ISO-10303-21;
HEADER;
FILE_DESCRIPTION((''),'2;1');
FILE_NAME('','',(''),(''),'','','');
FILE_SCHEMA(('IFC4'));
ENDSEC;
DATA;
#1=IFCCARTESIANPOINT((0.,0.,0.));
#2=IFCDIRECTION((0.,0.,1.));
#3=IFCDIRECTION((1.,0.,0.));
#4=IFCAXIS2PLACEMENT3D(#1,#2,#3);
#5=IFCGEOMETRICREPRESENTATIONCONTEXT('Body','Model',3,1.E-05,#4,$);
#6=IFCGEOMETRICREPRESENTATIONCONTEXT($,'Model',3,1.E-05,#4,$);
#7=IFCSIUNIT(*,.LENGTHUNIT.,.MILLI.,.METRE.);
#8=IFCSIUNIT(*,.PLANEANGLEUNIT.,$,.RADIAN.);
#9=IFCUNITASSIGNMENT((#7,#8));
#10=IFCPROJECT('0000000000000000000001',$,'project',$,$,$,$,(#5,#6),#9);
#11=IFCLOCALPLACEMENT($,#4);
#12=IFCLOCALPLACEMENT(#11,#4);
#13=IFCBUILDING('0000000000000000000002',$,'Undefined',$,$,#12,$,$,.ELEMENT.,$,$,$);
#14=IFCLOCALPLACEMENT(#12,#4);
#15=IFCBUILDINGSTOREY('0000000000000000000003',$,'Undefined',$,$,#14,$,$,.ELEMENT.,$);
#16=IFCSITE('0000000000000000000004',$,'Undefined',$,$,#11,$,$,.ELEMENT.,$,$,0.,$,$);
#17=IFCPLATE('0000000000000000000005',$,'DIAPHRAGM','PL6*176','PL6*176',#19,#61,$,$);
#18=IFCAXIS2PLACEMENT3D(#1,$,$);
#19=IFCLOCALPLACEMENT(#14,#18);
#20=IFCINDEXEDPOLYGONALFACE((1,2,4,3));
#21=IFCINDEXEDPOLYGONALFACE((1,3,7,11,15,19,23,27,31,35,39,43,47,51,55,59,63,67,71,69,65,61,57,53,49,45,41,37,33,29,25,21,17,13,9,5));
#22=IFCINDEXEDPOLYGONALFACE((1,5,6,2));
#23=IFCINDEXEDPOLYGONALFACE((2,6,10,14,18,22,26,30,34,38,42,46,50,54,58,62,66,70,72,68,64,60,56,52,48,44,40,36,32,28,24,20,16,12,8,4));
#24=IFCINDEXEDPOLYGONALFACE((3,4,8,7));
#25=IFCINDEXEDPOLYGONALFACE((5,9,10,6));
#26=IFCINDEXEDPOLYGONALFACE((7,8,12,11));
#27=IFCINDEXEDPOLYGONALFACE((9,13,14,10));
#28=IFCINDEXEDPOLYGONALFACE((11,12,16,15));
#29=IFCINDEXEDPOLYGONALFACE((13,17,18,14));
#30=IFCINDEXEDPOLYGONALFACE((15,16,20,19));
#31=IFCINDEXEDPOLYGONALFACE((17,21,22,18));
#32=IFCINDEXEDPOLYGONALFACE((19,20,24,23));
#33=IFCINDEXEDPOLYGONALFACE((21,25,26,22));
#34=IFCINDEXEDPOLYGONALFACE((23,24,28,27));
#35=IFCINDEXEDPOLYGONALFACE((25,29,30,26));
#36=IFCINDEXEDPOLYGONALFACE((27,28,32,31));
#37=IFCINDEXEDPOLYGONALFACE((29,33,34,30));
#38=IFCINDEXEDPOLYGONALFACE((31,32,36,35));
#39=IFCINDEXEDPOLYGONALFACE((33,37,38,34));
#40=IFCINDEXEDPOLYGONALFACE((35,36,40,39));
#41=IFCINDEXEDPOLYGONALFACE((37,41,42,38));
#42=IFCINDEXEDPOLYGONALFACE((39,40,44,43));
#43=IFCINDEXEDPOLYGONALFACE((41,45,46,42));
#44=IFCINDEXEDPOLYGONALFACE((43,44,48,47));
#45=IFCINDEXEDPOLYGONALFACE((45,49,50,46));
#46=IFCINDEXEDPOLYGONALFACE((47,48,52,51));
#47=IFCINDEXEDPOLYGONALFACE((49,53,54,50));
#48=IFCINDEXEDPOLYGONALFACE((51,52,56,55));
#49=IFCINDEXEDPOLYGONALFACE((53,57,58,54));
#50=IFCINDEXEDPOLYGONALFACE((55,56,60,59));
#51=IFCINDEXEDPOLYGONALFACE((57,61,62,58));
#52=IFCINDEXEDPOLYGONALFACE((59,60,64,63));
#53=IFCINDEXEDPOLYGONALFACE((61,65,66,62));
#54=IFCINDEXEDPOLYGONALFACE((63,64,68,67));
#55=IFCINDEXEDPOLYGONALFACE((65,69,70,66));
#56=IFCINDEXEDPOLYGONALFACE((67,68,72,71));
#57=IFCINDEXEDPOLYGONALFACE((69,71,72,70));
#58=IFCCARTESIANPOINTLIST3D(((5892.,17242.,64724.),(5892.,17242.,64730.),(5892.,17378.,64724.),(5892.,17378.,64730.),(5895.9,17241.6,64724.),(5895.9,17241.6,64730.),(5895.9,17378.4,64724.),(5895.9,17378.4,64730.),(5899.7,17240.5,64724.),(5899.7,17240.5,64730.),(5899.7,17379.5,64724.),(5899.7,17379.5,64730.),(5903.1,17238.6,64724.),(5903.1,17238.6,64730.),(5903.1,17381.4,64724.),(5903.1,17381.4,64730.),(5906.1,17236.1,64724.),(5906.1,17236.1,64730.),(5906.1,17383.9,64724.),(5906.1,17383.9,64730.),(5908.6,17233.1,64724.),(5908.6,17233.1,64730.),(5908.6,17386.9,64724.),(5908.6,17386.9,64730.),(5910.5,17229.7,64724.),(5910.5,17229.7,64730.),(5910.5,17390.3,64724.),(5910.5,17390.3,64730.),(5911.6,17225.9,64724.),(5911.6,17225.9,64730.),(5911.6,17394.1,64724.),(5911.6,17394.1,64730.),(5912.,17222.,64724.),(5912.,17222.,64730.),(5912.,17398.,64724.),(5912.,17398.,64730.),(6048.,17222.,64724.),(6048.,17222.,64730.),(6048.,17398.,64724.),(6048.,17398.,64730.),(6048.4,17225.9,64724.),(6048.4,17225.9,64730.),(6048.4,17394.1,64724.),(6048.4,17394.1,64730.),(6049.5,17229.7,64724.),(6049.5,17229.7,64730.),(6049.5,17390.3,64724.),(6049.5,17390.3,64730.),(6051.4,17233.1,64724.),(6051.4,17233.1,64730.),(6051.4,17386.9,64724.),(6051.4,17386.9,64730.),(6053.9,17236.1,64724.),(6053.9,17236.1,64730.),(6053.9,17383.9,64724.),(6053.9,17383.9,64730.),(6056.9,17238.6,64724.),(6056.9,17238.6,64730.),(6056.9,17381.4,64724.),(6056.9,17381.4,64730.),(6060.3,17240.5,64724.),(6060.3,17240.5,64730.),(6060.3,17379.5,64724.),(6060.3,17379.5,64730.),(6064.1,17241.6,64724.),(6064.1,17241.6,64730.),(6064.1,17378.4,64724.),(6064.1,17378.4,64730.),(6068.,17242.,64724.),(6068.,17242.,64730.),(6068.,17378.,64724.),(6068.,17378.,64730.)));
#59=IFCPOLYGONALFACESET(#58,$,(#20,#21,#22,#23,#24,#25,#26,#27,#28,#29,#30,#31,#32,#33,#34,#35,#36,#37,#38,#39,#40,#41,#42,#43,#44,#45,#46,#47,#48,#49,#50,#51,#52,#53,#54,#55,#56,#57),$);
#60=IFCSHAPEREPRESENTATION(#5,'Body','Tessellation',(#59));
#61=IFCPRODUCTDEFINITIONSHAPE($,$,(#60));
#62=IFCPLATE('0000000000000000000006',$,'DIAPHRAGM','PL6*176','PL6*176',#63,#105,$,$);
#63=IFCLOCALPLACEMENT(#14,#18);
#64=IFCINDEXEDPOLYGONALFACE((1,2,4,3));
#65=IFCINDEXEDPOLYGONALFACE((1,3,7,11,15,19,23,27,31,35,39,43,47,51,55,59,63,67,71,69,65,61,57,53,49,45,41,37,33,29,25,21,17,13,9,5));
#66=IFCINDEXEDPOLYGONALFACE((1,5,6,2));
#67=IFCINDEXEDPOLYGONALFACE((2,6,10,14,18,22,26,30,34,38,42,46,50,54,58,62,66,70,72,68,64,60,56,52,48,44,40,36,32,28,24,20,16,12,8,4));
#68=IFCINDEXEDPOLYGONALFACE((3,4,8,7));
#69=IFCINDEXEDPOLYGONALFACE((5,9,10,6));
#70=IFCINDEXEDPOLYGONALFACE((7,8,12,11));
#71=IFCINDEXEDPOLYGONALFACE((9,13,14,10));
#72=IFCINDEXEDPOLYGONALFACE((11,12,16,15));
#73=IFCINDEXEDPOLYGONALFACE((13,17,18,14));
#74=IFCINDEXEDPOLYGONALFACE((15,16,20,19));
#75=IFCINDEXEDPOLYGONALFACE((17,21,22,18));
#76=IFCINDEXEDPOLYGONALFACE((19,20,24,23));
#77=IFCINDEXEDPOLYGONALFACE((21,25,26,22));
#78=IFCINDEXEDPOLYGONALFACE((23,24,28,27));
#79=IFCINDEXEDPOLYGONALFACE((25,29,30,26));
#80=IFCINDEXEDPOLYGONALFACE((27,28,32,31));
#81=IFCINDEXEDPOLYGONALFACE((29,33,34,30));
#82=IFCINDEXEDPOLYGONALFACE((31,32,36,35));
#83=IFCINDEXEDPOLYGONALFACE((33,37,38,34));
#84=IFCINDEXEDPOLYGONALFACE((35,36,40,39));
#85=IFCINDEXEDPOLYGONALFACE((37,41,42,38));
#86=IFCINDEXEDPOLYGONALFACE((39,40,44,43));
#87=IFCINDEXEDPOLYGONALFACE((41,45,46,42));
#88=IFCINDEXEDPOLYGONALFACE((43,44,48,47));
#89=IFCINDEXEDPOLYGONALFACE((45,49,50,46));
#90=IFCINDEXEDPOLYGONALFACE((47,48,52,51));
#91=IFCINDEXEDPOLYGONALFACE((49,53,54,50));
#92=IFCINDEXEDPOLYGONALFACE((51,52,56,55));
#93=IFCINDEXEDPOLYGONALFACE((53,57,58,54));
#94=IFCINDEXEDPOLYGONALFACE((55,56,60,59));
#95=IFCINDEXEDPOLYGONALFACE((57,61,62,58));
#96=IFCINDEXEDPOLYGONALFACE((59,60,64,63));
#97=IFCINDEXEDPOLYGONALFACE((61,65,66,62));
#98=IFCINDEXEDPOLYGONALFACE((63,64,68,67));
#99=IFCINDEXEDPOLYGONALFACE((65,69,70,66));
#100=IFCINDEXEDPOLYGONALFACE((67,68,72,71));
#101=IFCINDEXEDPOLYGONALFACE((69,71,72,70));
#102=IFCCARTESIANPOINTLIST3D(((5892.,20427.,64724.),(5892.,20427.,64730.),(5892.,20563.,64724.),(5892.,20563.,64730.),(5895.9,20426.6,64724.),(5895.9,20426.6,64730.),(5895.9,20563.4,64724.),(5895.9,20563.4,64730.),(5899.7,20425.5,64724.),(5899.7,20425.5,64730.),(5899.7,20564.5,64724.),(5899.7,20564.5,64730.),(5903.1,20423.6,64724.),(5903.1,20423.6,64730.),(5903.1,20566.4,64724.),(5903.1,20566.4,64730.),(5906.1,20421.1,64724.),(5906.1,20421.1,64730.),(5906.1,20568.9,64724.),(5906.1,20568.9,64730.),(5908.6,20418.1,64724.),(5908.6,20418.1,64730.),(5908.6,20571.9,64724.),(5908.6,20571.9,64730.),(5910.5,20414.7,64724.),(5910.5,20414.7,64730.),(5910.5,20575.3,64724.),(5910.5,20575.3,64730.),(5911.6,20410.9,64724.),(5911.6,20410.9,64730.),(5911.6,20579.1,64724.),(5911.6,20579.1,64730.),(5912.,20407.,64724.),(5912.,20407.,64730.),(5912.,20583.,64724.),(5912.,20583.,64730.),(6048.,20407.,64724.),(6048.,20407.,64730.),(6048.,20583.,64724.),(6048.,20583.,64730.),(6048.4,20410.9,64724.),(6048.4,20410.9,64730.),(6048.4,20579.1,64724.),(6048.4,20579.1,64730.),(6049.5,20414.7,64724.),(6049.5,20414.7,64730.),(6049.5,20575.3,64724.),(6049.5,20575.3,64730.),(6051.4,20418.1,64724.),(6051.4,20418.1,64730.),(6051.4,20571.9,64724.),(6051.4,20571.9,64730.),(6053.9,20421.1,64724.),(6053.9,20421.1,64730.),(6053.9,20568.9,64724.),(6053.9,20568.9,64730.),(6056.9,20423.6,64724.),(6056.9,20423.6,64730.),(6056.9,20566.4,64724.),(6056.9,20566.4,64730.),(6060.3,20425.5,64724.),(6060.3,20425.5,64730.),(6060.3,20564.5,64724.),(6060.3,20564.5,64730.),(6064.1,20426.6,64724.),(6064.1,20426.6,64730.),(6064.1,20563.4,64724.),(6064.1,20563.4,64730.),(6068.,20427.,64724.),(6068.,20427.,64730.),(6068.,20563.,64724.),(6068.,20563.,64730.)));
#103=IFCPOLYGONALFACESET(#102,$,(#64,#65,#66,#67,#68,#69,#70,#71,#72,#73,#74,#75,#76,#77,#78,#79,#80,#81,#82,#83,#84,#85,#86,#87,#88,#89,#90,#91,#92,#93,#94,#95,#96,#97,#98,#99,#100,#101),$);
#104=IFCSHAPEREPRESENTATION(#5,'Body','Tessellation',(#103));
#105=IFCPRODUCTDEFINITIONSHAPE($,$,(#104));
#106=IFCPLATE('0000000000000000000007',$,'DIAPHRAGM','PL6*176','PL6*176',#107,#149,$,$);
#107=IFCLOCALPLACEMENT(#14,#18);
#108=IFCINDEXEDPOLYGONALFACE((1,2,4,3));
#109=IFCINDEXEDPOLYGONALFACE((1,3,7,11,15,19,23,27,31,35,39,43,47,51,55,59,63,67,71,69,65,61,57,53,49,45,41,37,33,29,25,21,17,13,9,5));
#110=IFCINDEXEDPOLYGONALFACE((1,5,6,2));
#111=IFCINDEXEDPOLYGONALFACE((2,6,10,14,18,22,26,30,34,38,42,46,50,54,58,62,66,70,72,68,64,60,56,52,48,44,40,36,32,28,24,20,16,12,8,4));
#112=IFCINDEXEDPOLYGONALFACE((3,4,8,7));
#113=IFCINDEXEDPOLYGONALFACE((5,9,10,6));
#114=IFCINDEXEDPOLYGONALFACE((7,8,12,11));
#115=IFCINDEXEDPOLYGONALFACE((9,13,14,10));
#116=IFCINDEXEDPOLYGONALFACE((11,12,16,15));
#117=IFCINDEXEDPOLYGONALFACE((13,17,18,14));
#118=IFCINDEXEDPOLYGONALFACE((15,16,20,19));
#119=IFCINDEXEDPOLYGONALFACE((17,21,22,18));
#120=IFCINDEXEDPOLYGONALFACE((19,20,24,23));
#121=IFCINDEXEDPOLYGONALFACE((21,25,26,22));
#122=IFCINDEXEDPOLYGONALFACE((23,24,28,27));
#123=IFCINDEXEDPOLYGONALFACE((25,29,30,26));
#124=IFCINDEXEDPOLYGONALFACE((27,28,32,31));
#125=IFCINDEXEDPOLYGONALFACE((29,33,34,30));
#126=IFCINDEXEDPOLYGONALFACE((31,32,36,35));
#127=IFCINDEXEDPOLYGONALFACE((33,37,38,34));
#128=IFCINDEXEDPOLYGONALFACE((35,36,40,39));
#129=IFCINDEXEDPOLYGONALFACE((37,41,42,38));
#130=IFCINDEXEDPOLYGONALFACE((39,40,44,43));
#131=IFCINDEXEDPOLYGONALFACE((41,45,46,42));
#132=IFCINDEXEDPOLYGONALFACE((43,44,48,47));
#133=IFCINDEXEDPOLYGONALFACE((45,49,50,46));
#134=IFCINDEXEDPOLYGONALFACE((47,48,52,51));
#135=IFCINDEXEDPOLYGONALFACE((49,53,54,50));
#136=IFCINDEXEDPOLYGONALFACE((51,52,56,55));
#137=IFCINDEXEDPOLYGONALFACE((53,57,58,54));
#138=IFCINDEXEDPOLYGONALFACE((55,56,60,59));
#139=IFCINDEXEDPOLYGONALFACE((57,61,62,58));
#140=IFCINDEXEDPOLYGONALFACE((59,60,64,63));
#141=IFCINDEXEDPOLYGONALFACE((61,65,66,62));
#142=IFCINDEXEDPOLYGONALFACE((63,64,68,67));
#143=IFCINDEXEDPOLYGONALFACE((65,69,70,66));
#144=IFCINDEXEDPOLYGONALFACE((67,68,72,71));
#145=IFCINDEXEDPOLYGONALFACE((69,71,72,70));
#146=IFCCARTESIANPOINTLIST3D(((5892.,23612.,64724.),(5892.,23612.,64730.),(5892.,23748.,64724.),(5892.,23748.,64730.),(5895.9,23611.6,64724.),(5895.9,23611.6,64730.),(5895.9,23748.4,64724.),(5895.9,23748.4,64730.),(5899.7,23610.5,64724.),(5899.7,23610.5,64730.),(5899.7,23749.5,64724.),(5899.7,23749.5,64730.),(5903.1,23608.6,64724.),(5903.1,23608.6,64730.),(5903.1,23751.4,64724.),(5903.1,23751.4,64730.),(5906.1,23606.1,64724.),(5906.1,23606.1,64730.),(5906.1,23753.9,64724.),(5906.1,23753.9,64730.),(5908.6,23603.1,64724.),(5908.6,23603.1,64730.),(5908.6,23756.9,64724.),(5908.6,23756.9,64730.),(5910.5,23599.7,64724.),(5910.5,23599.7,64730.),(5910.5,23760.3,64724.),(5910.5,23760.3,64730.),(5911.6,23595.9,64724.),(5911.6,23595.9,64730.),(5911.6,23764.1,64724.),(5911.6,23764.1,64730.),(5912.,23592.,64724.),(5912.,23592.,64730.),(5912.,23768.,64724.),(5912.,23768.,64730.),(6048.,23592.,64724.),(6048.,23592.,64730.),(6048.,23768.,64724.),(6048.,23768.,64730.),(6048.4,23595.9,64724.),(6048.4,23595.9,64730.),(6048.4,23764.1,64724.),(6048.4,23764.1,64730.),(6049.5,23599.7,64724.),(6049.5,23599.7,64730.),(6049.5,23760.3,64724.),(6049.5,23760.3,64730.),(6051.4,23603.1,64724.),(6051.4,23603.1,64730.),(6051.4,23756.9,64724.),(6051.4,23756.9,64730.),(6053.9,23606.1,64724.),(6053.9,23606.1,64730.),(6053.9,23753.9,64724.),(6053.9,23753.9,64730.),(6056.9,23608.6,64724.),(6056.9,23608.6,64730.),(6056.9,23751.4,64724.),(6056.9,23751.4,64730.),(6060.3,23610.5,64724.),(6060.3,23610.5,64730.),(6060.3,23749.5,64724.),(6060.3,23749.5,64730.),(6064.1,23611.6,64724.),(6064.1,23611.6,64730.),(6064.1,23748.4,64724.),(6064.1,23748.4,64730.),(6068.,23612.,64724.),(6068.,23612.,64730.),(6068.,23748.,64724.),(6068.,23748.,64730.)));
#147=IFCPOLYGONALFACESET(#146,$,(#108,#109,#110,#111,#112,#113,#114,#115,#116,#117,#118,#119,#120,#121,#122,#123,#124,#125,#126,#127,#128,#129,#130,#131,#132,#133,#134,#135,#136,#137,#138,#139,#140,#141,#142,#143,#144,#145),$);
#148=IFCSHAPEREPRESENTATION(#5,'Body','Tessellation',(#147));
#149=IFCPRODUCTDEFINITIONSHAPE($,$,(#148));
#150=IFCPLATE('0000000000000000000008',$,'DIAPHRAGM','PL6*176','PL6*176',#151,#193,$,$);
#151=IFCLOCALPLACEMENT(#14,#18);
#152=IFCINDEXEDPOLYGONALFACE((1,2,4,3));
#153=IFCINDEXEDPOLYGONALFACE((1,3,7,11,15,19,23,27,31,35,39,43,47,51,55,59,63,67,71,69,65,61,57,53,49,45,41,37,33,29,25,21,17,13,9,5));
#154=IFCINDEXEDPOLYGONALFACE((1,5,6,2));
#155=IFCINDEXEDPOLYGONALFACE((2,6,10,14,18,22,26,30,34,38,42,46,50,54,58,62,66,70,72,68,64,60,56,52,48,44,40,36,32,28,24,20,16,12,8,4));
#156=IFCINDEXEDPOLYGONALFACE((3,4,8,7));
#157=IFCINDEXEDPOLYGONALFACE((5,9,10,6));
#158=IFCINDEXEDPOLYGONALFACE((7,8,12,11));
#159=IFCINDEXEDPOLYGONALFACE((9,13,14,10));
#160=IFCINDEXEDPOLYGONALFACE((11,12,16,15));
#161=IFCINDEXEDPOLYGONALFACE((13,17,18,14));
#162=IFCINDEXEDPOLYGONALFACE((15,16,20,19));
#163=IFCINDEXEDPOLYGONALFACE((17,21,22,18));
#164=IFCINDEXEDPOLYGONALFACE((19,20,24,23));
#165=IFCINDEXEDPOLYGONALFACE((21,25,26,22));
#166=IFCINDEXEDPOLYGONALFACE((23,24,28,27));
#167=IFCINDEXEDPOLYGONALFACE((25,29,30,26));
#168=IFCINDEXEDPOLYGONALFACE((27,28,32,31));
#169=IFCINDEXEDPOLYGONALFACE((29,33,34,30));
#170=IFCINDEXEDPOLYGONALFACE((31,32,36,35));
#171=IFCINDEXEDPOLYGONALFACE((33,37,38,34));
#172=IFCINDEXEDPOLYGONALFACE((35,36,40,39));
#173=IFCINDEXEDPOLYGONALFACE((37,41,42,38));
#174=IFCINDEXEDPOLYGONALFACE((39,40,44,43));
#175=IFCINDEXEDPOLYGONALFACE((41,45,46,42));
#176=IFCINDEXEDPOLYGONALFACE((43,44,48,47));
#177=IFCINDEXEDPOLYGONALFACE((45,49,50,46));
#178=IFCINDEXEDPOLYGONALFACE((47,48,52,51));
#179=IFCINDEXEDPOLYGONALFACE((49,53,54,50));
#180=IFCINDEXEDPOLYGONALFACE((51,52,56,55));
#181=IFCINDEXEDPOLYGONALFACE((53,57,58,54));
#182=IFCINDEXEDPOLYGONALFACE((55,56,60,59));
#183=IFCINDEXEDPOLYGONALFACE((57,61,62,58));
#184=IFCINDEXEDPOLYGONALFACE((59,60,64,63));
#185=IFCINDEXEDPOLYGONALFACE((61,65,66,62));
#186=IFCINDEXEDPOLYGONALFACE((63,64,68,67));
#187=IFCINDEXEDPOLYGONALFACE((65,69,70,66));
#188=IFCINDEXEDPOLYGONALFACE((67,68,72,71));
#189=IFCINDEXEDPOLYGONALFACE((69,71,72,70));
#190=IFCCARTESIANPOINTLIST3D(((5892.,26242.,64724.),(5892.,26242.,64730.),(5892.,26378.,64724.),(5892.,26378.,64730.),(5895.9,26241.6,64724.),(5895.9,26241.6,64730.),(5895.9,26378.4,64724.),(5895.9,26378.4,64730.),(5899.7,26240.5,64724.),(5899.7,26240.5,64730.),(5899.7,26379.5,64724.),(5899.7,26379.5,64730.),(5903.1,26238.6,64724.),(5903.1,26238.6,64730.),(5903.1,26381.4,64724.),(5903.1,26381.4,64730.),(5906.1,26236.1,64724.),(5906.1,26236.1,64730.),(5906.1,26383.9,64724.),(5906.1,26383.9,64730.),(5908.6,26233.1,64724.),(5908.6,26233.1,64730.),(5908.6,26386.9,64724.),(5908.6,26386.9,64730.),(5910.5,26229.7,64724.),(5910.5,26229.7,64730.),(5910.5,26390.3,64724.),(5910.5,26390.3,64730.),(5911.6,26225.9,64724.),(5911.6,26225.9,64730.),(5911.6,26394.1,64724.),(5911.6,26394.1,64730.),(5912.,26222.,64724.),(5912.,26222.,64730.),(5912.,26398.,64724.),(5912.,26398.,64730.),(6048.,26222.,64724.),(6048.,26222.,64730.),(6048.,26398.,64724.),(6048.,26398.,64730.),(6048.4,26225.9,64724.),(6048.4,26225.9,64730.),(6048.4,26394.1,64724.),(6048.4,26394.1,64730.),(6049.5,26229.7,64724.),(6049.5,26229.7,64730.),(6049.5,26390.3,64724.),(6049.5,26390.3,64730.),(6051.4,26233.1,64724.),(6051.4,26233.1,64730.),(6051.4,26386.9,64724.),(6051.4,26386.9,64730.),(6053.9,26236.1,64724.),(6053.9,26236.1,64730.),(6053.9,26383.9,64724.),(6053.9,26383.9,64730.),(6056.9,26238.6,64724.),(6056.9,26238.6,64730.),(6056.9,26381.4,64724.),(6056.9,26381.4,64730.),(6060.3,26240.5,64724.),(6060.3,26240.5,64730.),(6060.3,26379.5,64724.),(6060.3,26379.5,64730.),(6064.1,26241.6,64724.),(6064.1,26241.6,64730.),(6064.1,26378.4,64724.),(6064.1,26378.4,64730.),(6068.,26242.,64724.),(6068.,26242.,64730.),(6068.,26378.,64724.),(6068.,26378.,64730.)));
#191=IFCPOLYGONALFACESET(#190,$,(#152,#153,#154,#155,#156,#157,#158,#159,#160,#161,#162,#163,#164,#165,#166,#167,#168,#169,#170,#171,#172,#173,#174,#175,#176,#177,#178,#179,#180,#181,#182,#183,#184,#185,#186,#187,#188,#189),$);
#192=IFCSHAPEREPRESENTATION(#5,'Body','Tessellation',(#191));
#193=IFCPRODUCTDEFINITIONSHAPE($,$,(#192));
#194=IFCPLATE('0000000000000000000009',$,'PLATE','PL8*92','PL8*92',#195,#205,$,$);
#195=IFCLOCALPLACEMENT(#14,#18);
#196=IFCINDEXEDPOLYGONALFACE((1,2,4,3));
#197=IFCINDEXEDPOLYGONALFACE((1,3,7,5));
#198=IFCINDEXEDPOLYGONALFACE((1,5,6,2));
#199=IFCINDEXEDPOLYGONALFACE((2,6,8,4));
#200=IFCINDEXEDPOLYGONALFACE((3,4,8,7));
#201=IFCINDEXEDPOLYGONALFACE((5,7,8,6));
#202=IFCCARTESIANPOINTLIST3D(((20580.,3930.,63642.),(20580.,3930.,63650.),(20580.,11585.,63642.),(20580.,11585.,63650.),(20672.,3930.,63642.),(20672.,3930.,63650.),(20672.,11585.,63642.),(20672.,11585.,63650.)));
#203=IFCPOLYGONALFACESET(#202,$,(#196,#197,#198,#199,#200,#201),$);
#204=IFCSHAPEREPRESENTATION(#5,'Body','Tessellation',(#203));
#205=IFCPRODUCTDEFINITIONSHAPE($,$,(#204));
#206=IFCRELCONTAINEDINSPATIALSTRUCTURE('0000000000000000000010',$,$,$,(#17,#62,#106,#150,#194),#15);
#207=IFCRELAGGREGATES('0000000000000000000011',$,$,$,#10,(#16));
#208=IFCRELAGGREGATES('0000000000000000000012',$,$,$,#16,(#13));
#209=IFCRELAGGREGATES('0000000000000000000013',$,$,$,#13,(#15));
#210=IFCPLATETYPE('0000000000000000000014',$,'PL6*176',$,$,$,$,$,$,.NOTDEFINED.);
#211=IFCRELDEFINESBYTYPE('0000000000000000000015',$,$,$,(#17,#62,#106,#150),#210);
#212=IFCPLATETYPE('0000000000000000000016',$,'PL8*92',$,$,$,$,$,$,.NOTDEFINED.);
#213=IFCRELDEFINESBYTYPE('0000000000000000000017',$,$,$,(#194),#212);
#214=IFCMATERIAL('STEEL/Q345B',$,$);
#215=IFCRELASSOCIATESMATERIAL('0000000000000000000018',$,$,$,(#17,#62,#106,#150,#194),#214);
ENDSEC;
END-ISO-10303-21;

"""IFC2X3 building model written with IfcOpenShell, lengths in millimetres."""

from ifc_helpers import new_model, si_unit, frame, origin_with_axes, place, context, project, spatial, polyline, outline, extrude, material, type_object, element, save


model = new_model("IFC2X3")

# Units and contexts
model_context_1 = context("Model", 3, precision=1e-05, world=origin_with_axes(), identifier="Body")
model_context_2 = context("Model", 3, precision=1e-05, world=origin_with_axes())
ifc_project = project(units=[si_unit("LENGTHUNIT", "METRE", prefix="MILLI"), si_unit("PLANEANGLEUNIT", "RADIAN")], contexts=[model_context_1, model_context_2])

# Site, building, storey
site_placement = place(None, origin_with_axes())
site = spatial("IfcSite", under=ifc_project, at=site_placement, Name="Undefined", CompositionType="ELEMENT", RefElevation=0.0)
building_placement = place(site_placement, origin_with_axes())
building = spatial("IfcBuilding", under=site, at=building_placement, Name="Undefined", CompositionType="ELEMENT")
storey_placement = place(building_placement, origin_with_axes())
storey = spatial("IfcBuildingStorey", under=building, at=storey_placement, Name="Undefined", CompositionType="ELEMENT")

# Shared definitions
ifc_material_1 = material(Name="STEEL/Q345B")

# Plates
plate_type_1 = type_object("IfcPlateType", Name="PL6*176", PredefinedType="NOTDEFINED")
for number, where, z_axis, x_axis, name in (
    (1, (6068.0, 17222.0, 64727.0), (0.0, 0.0, -1.0), (-1.0, 0.0, 0.0), "DIAPHRAGM"),
    (2, (6068.0, 20407.0, 64727.0), (0.0, 0.0, -1.0), (-1.0, 0.0, 0.0), "DIAPHRAGM"),
    (3, (6068.0, 23592.0, 64727.0), (0.0, 0.0, -1.0), (-1.0, 0.0, 0.0), "DIAPHRAGM"),
    (4, (6068.0, 26222.0, 64727.0), (0.0, 0.0, -1.0), (-1.0, 0.0, 0.0), "DIAPHRAGM"),
):
    element("IfcPlate", number, at=place(storey_placement, frame(where, z_axis=z_axis, x_axis=x_axis)), inside=storey, type_object=plate_type_1, material=ifc_material_1, Name=name, Description="PL6*176", ObjectType="PL6*176", context=model_context_1, shape_type="SweptSolid", body=[
        extrude(outline(polyline([(0.0, 20.0), (3.9, 19.6), (7.7, 18.5), (11.1, 16.6), (14.1, 14.1), (16.6, 11.1), (18.5, 7.7), (19.6, 3.9), (20.0, 0.0), (156.0, 0.0), (156.4, 3.9), (157.5, 7.7), (159.4, 11.1), (161.9, 14.1), (164.9, 16.6), (168.3, 18.5), (172.1, 19.6), (176.0, 20.0), (176.0, 156.0), (172.1, 156.4), (168.3, 157.5), (164.9, 159.4), (161.9, 161.9), (159.4, 164.9), (157.5, 168.3), (156.4, 172.1), (156.0, 176.0), (20.0, 176.0), (19.6, 172.1), (18.5, 168.3), (16.6, 164.9), (14.1, 161.9), (11.1, 159.4), (7.7, 157.5), (3.9, 156.4), (0.0, 156.0), (0.0, 20.0)])), frame((0.0, 0.0, -3.0), z_axis=(0.0, 0.0, 1.0), x_axis=(1.0, 0.0, 0.0)), (0.0, 0.0, 1.0), 6.0),
    ])
plate_type_2 = type_object("IfcPlateType", Name="PL8*92", PredefinedType="NOTDEFINED")
plate_1_placement = place(storey_placement, frame((20580.0, 11585.0, 63646.0), z_axis=(0.0, 0.0, 1.0), x_axis=(0.0, -1.0, 0.0)))
element("IfcPlate", 5, at=plate_1_placement, inside=storey, type_object=plate_type_2, material=ifc_material_1, Name="PLATE", Description="PL8*92", ObjectType="PL8*92", context=model_context_1, shape_type="SweptSolid", body=[
    extrude(outline(polyline([(0.0, 0.0), (7655.0, 0.0), (7655.0, 92.0), (0.0, 92.0), (0.0, 0.0)])), frame((0.0, 0.0, -4.0), z_axis=(0.0, 0.0, 1.0), x_axis=(1.0, 0.0, 0.0)), (0.0, 0.0, 1.0), 8.0),
])

save(model, "model.ifc")
